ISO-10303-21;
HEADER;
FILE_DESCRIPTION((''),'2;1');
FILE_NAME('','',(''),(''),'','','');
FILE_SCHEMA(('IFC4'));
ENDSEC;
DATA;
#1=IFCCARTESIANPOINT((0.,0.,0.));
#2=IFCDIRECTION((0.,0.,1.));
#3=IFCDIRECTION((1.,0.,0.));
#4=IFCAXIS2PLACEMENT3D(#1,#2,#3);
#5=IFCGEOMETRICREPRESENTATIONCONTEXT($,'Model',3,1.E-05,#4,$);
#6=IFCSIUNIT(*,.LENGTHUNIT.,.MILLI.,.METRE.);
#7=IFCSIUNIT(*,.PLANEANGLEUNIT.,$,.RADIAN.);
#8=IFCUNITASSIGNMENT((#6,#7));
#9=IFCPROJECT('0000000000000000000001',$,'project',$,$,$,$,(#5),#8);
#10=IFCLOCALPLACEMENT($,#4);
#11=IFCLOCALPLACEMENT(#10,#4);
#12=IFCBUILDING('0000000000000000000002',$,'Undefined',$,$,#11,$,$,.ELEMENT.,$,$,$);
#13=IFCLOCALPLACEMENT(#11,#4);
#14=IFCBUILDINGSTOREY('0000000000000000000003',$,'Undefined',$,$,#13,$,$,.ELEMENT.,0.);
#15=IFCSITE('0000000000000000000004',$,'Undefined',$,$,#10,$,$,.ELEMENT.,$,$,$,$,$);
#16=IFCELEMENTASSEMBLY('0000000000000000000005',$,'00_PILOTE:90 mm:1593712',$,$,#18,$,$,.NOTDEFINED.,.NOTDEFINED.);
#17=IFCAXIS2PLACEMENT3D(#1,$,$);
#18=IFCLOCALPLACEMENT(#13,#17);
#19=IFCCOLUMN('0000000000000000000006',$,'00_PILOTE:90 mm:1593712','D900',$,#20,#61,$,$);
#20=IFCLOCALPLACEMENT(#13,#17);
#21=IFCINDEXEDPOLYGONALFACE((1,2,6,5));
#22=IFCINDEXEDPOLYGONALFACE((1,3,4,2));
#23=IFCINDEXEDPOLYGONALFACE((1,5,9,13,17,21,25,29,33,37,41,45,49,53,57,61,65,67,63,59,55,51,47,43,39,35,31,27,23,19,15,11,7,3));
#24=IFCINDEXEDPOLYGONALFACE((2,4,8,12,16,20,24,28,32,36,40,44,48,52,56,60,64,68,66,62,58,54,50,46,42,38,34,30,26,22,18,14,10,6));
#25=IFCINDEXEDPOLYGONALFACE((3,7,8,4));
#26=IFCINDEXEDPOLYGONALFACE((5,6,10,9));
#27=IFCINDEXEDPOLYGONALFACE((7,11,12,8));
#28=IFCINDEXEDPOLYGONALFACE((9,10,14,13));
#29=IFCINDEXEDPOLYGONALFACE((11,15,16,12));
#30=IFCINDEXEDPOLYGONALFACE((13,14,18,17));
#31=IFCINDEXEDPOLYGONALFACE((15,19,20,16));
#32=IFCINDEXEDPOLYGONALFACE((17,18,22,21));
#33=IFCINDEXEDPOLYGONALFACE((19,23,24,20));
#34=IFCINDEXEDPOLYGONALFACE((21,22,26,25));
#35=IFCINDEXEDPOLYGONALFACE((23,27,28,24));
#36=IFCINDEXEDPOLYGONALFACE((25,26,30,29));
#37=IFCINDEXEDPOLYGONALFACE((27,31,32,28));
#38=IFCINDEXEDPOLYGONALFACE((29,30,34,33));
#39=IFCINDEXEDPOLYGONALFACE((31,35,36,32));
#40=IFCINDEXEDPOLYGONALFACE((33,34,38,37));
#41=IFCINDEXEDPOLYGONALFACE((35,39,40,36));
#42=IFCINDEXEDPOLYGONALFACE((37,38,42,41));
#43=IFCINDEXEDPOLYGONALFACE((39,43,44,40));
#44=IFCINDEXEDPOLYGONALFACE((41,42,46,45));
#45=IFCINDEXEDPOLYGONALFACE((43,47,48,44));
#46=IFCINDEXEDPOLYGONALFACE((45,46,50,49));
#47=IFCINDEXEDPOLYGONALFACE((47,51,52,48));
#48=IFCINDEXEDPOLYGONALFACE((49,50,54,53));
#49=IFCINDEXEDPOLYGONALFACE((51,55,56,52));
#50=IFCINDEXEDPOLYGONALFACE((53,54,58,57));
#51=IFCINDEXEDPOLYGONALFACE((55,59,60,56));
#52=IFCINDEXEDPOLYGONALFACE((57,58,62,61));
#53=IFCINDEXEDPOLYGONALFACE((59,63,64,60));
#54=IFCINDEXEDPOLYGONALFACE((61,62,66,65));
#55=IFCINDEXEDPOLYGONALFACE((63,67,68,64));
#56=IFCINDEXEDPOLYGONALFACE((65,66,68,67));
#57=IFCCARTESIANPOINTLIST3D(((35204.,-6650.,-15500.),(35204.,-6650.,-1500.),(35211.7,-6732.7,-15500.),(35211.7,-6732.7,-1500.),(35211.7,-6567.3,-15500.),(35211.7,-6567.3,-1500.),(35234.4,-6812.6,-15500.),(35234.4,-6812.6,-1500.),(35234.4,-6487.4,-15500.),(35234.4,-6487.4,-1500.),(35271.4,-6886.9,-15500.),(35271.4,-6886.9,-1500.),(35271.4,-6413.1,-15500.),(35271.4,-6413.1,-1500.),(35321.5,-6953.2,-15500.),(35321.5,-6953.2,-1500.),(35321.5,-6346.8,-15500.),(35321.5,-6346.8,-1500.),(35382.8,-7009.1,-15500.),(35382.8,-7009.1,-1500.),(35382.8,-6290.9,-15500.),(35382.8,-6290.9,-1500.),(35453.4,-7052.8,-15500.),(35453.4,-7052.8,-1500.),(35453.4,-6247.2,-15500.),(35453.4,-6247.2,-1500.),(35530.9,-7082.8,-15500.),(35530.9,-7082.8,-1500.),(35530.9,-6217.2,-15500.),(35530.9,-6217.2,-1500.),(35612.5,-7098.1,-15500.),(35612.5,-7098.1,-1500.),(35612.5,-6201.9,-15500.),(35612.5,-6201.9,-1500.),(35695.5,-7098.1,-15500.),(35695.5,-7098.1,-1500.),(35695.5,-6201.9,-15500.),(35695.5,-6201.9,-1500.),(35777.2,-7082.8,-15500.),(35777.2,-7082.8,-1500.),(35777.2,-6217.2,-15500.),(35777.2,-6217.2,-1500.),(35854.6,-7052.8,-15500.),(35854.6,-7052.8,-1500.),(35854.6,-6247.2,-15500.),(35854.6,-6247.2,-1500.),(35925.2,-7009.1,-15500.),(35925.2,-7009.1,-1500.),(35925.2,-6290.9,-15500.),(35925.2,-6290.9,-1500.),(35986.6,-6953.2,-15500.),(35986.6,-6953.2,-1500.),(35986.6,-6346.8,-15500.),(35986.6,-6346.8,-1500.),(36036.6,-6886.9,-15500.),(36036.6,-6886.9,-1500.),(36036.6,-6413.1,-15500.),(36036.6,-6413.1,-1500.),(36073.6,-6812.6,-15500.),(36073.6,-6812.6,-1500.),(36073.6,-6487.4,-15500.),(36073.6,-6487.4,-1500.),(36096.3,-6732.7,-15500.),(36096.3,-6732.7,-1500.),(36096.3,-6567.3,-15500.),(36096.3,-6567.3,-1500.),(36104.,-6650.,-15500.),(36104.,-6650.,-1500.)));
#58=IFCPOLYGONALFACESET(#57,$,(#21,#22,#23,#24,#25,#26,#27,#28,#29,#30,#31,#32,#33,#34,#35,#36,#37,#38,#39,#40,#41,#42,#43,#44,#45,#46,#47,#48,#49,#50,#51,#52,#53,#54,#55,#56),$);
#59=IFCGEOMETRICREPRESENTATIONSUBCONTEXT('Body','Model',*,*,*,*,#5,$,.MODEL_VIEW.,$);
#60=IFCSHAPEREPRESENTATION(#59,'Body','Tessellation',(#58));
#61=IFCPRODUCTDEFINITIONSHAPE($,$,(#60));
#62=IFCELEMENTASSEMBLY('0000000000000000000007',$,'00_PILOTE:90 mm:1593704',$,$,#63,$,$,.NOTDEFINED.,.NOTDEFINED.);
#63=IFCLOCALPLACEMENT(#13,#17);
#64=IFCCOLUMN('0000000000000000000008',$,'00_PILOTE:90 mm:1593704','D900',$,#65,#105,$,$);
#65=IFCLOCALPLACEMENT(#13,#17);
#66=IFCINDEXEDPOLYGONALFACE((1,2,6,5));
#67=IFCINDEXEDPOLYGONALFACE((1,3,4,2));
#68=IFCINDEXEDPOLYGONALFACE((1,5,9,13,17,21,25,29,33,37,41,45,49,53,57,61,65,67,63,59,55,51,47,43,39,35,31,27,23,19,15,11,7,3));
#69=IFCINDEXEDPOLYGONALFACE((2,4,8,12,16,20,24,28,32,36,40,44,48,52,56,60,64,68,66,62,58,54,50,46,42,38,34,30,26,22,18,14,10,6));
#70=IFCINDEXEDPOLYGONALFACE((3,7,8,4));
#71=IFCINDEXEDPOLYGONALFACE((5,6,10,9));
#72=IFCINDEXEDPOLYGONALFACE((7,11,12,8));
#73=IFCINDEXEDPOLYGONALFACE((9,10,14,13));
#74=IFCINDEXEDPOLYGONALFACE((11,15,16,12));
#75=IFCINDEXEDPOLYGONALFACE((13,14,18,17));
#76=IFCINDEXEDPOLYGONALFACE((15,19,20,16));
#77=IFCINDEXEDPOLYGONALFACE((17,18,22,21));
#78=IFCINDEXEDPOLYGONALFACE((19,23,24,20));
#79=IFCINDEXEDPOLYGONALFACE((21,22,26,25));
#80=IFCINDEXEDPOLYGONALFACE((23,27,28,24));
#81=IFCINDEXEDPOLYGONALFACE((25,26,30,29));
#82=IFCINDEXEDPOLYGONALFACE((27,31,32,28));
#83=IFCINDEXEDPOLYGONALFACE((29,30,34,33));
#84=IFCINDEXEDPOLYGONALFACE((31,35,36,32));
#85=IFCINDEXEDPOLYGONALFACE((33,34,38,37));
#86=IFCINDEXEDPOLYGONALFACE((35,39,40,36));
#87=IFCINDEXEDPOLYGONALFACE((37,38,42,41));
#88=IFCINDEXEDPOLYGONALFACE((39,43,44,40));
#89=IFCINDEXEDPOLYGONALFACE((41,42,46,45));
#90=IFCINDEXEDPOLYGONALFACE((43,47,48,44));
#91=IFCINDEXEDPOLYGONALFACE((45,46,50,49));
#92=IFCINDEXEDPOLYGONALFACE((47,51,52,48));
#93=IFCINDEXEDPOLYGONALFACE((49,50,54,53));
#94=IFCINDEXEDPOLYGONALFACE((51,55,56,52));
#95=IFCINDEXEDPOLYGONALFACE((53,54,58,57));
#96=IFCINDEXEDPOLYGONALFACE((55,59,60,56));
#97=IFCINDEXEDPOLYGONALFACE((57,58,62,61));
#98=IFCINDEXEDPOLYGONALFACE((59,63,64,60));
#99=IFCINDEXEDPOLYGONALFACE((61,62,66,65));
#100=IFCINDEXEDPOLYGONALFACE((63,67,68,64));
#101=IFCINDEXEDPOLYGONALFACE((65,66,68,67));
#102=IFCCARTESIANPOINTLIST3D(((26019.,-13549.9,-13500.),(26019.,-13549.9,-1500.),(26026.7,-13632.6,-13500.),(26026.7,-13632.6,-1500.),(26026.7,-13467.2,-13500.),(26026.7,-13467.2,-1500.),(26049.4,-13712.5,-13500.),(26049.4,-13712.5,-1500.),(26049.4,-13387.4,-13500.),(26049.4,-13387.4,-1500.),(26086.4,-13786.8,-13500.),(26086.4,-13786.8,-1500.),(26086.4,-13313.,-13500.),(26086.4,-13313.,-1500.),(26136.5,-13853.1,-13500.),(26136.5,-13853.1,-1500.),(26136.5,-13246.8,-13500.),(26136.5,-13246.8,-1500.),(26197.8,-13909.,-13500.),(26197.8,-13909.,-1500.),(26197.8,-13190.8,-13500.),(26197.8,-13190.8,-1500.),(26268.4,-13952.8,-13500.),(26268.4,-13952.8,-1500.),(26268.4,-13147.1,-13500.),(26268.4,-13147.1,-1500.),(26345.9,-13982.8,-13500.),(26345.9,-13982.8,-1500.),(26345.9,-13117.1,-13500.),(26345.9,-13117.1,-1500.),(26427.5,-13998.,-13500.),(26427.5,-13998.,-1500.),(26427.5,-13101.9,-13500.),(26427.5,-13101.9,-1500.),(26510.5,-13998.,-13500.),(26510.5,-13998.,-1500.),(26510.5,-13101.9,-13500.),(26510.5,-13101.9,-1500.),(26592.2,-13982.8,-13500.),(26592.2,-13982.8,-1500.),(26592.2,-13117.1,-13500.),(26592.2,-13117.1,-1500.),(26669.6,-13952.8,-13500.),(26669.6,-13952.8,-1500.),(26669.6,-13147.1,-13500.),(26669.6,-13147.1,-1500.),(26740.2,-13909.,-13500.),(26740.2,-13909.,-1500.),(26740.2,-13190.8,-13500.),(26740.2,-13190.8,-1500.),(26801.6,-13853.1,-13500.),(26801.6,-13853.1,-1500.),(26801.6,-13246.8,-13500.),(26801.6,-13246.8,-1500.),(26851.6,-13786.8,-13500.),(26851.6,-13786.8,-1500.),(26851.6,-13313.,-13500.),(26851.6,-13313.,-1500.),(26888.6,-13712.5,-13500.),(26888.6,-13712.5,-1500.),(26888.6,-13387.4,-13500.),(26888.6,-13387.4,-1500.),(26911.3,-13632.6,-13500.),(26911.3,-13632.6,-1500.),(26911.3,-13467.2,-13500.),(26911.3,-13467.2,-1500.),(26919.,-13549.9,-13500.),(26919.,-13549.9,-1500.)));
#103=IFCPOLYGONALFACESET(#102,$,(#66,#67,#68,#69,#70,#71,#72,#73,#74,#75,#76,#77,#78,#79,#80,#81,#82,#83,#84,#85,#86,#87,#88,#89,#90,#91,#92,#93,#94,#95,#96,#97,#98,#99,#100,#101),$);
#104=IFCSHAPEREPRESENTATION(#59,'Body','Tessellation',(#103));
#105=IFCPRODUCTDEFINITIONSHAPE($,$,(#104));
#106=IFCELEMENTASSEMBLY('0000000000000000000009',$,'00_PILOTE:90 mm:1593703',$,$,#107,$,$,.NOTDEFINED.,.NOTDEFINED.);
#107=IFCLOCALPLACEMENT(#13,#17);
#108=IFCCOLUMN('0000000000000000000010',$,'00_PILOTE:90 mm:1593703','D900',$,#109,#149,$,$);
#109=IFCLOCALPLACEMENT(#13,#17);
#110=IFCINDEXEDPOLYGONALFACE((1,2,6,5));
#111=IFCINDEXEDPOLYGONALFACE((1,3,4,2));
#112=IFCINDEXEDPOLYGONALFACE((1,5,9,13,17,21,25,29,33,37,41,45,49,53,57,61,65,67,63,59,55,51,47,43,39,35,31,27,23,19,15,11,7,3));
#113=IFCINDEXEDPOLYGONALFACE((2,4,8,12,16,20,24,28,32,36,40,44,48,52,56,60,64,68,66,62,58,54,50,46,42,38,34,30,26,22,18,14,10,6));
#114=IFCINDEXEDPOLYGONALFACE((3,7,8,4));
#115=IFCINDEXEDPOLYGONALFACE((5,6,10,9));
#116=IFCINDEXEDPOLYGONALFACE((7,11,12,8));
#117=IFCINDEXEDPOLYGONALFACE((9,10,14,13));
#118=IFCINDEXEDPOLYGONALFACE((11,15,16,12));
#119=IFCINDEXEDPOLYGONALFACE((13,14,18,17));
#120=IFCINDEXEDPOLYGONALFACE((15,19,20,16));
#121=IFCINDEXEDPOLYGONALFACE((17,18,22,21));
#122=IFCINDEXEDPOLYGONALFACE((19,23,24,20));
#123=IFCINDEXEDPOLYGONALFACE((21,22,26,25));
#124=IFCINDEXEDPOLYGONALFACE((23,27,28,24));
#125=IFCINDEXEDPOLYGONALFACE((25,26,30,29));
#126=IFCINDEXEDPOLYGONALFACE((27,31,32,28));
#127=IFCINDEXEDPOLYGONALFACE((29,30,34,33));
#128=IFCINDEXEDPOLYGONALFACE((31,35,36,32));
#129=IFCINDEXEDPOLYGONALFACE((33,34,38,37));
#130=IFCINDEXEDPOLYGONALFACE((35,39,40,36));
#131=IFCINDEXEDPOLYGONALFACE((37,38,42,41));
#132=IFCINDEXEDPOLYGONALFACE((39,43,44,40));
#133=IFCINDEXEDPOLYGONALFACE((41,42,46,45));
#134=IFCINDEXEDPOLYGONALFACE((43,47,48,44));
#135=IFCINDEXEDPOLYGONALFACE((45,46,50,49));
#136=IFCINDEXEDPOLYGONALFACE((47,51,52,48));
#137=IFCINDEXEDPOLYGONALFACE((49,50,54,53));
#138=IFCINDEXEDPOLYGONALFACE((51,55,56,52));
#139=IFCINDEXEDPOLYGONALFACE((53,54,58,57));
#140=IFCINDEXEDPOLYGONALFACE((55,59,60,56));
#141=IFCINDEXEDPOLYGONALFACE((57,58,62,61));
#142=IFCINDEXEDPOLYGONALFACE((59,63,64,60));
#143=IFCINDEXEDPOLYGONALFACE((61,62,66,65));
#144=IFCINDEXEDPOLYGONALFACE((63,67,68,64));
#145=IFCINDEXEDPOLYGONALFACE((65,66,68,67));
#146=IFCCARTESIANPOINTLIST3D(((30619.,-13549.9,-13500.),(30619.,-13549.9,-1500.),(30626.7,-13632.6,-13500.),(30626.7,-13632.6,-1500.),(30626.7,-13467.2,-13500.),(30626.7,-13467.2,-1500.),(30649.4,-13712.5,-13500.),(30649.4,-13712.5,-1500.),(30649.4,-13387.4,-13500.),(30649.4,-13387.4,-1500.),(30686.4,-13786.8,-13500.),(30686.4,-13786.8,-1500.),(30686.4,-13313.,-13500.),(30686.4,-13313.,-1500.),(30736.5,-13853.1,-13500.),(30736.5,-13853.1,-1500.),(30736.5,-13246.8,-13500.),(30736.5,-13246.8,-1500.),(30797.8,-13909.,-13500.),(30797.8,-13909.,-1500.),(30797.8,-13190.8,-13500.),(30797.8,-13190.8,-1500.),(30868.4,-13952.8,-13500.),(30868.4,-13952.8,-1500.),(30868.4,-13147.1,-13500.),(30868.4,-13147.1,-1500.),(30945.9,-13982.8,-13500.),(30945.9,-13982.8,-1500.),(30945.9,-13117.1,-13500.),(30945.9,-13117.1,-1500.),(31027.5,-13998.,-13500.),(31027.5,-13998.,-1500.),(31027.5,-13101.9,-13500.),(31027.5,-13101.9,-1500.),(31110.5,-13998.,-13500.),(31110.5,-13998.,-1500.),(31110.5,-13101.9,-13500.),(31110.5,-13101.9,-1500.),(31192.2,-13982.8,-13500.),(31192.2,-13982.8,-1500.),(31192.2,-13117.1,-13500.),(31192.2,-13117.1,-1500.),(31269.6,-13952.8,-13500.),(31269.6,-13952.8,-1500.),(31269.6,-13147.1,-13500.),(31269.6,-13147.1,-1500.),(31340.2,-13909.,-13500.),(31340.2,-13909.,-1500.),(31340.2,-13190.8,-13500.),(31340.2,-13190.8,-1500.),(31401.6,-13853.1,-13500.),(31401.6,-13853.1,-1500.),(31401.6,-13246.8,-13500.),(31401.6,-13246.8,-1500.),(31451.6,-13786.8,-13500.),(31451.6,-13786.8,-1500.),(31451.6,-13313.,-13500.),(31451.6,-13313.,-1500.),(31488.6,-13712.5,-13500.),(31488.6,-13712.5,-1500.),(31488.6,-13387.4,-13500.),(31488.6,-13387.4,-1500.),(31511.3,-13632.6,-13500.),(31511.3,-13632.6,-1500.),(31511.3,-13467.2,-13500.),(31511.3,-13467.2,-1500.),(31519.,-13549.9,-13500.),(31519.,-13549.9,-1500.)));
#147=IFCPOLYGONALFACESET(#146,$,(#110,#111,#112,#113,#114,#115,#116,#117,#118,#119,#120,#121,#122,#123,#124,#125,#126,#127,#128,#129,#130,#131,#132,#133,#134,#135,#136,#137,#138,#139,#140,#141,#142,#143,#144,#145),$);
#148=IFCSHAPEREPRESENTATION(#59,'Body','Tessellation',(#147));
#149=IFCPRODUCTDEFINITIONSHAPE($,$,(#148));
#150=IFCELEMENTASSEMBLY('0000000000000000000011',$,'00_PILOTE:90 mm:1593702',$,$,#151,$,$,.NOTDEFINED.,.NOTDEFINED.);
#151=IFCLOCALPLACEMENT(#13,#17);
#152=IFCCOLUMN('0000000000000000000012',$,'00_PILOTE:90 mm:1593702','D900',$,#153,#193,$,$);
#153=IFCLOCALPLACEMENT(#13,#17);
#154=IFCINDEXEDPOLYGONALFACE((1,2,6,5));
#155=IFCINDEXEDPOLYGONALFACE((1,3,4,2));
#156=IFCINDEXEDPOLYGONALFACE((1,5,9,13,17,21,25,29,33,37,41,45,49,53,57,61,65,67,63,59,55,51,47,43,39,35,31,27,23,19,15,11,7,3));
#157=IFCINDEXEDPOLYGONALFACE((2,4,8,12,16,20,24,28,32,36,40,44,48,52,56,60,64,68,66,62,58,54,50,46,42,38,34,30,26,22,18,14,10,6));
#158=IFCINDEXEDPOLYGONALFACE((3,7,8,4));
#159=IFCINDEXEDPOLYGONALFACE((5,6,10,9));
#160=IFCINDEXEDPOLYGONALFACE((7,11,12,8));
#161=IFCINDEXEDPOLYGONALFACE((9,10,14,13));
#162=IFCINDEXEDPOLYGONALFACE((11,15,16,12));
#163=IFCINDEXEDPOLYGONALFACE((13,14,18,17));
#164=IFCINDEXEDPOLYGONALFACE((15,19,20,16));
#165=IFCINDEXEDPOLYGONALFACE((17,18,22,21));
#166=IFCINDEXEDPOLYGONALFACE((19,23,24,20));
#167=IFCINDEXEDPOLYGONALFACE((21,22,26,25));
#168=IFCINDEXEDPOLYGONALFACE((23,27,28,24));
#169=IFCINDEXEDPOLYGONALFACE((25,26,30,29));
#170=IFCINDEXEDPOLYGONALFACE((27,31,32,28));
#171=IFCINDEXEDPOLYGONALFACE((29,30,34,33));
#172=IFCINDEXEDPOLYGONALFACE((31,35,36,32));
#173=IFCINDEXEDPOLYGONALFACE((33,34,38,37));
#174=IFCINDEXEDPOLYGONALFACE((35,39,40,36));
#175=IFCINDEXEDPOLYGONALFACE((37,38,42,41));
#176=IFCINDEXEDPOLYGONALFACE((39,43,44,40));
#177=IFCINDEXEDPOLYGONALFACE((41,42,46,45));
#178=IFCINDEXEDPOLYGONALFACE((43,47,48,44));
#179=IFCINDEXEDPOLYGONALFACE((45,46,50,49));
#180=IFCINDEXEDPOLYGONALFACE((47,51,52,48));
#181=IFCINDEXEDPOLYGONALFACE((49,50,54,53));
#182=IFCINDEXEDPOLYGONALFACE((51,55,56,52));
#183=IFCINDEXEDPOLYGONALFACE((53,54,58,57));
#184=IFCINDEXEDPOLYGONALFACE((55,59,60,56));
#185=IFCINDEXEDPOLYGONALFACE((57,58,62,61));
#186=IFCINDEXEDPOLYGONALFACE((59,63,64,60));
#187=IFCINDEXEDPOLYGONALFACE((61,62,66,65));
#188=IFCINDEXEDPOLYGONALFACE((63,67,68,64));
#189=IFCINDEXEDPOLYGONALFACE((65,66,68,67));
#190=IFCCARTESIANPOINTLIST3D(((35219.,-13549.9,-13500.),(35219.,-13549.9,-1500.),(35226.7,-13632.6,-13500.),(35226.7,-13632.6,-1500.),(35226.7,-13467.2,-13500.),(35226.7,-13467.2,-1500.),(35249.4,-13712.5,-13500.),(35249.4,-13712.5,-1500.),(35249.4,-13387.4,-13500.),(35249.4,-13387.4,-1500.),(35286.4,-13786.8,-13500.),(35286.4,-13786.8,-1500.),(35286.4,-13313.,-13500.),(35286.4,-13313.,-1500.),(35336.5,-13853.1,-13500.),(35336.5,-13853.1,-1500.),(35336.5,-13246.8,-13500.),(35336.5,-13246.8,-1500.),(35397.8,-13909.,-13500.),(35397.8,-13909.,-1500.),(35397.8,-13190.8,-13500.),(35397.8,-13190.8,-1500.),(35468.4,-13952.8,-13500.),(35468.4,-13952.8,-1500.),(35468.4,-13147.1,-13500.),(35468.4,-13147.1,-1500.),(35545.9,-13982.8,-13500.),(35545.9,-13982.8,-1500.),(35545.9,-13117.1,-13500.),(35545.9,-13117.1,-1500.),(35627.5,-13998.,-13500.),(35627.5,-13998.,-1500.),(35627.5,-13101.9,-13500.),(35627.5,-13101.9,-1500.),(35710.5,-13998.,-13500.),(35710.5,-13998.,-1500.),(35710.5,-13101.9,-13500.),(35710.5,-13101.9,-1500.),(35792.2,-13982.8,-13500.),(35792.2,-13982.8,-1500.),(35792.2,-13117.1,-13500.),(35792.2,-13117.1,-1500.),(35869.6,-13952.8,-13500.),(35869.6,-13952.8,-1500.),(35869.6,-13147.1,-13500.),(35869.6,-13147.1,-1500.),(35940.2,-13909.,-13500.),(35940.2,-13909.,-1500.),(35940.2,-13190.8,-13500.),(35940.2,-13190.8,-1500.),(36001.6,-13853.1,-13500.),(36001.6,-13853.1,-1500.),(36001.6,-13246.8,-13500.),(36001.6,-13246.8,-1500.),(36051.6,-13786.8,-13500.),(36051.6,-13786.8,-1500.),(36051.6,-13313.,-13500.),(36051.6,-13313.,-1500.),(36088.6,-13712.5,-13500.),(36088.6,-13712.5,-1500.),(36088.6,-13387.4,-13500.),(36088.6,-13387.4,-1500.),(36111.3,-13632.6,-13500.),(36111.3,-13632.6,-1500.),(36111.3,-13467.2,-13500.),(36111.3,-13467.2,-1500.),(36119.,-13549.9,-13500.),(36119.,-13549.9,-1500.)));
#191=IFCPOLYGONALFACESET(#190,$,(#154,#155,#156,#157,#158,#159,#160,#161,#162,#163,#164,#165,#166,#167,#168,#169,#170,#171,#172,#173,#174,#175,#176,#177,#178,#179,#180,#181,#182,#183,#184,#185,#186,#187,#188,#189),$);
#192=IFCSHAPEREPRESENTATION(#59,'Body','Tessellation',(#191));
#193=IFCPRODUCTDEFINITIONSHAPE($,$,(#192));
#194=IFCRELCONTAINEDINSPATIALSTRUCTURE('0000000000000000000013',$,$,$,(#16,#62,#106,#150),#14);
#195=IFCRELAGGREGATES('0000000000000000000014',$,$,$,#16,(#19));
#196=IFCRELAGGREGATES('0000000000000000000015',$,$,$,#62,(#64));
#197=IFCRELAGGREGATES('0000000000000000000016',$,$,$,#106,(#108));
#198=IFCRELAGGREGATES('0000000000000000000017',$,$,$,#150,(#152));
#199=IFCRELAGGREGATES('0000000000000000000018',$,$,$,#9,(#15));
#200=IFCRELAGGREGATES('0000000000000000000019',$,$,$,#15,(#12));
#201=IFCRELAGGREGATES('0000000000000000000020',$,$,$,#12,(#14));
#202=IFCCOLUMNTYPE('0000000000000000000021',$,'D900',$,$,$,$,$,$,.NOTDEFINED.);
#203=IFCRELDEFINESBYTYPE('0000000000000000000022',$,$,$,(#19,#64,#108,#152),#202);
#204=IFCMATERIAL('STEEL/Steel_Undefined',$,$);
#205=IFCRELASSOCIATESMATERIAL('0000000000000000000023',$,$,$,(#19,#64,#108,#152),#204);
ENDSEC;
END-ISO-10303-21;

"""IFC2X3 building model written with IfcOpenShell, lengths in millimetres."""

from ifc_helpers import new_model, si_unit, frame, origin_with_axes, origin_2d_with_axis, place, context, subcontext, project, spatial, circle, extrude, material, type_object, element, aggregate, save


model = new_model("IFC2X3")

# Units and contexts
model_context = context("Model", 3, precision=1e-05, world=origin_with_axes())
body_context = subcontext(model_context, "Body", "Model", "MODEL_VIEW")
ifc_project = project(units=[si_unit("LENGTHUNIT", "METRE", prefix="MILLI"), si_unit("PLANEANGLEUNIT", "RADIAN")], contexts=[model_context])

# Site, building, storey
site_placement = place(None, origin_with_axes())
site = spatial("IfcSite", under=ifc_project, at=site_placement, Name="Undefined", CompositionType="ELEMENT")
building_placement = place(site_placement, origin_with_axes())
building = spatial("IfcBuilding", under=site, at=building_placement, Name="Undefined", CompositionType="ELEMENT")
storey_placement = place(building_placement, origin_with_axes())
storey = spatial("IfcBuildingStorey", under=building, at=storey_placement, Name="Undefined", CompositionType="ELEMENT", Elevation=0.0)

# Element assemblies, columns
ifc_material_1 = material(Name="STEEL/Steel_Undefined")
column_type_1 = type_object("IfcColumnType", Name="D900", PredefinedType="NOTDEFINED")
assembly_1_placement = place(storey_placement, origin_with_axes())
assembly_1 = element("IfcElementAssembly", 1, at=assembly_1_placement, inside=storey, Name="00_PILOTE:90 mm:1593712", AssemblyPlace="NOTDEFINED", PredefinedType="NOTDEFINED")
column_1_placement = place(assembly_1_placement, frame((35654.0, -6650.0, -15500.0), z_axis=(0.0, 0.0, 1.0), x_axis=(0.0, 1.0, 0.0)))
column_1 = element("IfcColumn", 2, at=column_1_placement, type_object=column_type_1, material=ifc_material_1, Name="00_PILOTE:90 mm:1593712", Description="D900", context=body_context, shape_type="SweptSolid", body=[
    extrude(circle(Radius=450.0, at=origin_2d_with_axis()), frame((0.0, 0.0, 14000.0), z_axis=(0.0, 0.0, -1.0), x_axis=(0.0, 1.0, 0.0)), (0.0, 0.0, 1.0), 14000.0),
])
aggregate(assembly_1, [column_1])
assembly_2_placement = place(storey_placement, origin_with_axes())
assembly_2 = element("IfcElementAssembly", 3, at=assembly_2_placement, inside=storey, Name="00_PILOTE:90 mm:1593704", AssemblyPlace="NOTDEFINED", PredefinedType="NOTDEFINED")
column_2_placement = place(assembly_2_placement, frame((26469.0, -13549.9, -13500.0), z_axis=(0.0, 0.0, 1.0), x_axis=(0.0, 1.0, 0.0)))
column_2 = element("IfcColumn", 4, at=column_2_placement, type_object=column_type_1, material=ifc_material_1, Name="00_PILOTE:90 mm:1593704", Description="D900", context=body_context, shape_type="SweptSolid", body=[
    extrude(circle(Radius=450.0, at=origin_2d_with_axis()), frame((0.0, 0.0, 12000.0), z_axis=(0.0, 0.0, -1.0), x_axis=(0.0, 1.0, 0.0)), (0.0, 0.0, 1.0), 12000.0),
])
aggregate(assembly_2, [column_2])
assembly_3_placement = place(storey_placement, origin_with_axes())
assembly_3 = element("IfcElementAssembly", 5, at=assembly_3_placement, inside=storey, Name="00_PILOTE:90 mm:1593703", AssemblyPlace="NOTDEFINED", PredefinedType="NOTDEFINED")
column_3_placement = place(assembly_3_placement, frame((31069.0, -13549.9, -13500.0), z_axis=(0.0, 0.0, 1.0), x_axis=(0.0, 1.0, 0.0)))
column_3 = element("IfcColumn", 6, at=column_3_placement, type_object=column_type_1, material=ifc_material_1, Name="00_PILOTE:90 mm:1593703", Description="D900", context=body_context, shape_type="SweptSolid", body=[
    extrude(circle(Radius=450.0, at=origin_2d_with_axis()), frame((0.0, 0.0, 12000.0), z_axis=(0.0, 0.0, -1.0), x_axis=(0.0, 1.0, 0.0)), (0.0, 0.0, 1.0), 12000.0),
])
aggregate(assembly_3, [column_3])
assembly_4_placement = place(storey_placement, origin_with_axes())
assembly_4 = element("IfcElementAssembly", 7, at=assembly_4_placement, inside=storey, Name="00_PILOTE:90 mm:1593702", AssemblyPlace="NOTDEFINED", PredefinedType="NOTDEFINED")
column_4_placement = place(assembly_4_placement, frame((35669.0, -13549.9, -13500.0), z_axis=(0.0, 0.0, 1.0), x_axis=(0.0, 1.0, 0.0)))
column_4 = element("IfcColumn", 8, at=column_4_placement, type_object=column_type_1, material=ifc_material_1, Name="00_PILOTE:90 mm:1593702", Description="D900", context=body_context, shape_type="SweptSolid", body=[
    extrude(circle(Radius=450.0, at=origin_2d_with_axis()), frame((0.0, 0.0, 12000.0), z_axis=(0.0, 0.0, -1.0), x_axis=(0.0, 1.0, 0.0)), (0.0, 0.0, 1.0), 12000.0),
])
aggregate(assembly_4, [column_4])

save(model, "model.ifc")
